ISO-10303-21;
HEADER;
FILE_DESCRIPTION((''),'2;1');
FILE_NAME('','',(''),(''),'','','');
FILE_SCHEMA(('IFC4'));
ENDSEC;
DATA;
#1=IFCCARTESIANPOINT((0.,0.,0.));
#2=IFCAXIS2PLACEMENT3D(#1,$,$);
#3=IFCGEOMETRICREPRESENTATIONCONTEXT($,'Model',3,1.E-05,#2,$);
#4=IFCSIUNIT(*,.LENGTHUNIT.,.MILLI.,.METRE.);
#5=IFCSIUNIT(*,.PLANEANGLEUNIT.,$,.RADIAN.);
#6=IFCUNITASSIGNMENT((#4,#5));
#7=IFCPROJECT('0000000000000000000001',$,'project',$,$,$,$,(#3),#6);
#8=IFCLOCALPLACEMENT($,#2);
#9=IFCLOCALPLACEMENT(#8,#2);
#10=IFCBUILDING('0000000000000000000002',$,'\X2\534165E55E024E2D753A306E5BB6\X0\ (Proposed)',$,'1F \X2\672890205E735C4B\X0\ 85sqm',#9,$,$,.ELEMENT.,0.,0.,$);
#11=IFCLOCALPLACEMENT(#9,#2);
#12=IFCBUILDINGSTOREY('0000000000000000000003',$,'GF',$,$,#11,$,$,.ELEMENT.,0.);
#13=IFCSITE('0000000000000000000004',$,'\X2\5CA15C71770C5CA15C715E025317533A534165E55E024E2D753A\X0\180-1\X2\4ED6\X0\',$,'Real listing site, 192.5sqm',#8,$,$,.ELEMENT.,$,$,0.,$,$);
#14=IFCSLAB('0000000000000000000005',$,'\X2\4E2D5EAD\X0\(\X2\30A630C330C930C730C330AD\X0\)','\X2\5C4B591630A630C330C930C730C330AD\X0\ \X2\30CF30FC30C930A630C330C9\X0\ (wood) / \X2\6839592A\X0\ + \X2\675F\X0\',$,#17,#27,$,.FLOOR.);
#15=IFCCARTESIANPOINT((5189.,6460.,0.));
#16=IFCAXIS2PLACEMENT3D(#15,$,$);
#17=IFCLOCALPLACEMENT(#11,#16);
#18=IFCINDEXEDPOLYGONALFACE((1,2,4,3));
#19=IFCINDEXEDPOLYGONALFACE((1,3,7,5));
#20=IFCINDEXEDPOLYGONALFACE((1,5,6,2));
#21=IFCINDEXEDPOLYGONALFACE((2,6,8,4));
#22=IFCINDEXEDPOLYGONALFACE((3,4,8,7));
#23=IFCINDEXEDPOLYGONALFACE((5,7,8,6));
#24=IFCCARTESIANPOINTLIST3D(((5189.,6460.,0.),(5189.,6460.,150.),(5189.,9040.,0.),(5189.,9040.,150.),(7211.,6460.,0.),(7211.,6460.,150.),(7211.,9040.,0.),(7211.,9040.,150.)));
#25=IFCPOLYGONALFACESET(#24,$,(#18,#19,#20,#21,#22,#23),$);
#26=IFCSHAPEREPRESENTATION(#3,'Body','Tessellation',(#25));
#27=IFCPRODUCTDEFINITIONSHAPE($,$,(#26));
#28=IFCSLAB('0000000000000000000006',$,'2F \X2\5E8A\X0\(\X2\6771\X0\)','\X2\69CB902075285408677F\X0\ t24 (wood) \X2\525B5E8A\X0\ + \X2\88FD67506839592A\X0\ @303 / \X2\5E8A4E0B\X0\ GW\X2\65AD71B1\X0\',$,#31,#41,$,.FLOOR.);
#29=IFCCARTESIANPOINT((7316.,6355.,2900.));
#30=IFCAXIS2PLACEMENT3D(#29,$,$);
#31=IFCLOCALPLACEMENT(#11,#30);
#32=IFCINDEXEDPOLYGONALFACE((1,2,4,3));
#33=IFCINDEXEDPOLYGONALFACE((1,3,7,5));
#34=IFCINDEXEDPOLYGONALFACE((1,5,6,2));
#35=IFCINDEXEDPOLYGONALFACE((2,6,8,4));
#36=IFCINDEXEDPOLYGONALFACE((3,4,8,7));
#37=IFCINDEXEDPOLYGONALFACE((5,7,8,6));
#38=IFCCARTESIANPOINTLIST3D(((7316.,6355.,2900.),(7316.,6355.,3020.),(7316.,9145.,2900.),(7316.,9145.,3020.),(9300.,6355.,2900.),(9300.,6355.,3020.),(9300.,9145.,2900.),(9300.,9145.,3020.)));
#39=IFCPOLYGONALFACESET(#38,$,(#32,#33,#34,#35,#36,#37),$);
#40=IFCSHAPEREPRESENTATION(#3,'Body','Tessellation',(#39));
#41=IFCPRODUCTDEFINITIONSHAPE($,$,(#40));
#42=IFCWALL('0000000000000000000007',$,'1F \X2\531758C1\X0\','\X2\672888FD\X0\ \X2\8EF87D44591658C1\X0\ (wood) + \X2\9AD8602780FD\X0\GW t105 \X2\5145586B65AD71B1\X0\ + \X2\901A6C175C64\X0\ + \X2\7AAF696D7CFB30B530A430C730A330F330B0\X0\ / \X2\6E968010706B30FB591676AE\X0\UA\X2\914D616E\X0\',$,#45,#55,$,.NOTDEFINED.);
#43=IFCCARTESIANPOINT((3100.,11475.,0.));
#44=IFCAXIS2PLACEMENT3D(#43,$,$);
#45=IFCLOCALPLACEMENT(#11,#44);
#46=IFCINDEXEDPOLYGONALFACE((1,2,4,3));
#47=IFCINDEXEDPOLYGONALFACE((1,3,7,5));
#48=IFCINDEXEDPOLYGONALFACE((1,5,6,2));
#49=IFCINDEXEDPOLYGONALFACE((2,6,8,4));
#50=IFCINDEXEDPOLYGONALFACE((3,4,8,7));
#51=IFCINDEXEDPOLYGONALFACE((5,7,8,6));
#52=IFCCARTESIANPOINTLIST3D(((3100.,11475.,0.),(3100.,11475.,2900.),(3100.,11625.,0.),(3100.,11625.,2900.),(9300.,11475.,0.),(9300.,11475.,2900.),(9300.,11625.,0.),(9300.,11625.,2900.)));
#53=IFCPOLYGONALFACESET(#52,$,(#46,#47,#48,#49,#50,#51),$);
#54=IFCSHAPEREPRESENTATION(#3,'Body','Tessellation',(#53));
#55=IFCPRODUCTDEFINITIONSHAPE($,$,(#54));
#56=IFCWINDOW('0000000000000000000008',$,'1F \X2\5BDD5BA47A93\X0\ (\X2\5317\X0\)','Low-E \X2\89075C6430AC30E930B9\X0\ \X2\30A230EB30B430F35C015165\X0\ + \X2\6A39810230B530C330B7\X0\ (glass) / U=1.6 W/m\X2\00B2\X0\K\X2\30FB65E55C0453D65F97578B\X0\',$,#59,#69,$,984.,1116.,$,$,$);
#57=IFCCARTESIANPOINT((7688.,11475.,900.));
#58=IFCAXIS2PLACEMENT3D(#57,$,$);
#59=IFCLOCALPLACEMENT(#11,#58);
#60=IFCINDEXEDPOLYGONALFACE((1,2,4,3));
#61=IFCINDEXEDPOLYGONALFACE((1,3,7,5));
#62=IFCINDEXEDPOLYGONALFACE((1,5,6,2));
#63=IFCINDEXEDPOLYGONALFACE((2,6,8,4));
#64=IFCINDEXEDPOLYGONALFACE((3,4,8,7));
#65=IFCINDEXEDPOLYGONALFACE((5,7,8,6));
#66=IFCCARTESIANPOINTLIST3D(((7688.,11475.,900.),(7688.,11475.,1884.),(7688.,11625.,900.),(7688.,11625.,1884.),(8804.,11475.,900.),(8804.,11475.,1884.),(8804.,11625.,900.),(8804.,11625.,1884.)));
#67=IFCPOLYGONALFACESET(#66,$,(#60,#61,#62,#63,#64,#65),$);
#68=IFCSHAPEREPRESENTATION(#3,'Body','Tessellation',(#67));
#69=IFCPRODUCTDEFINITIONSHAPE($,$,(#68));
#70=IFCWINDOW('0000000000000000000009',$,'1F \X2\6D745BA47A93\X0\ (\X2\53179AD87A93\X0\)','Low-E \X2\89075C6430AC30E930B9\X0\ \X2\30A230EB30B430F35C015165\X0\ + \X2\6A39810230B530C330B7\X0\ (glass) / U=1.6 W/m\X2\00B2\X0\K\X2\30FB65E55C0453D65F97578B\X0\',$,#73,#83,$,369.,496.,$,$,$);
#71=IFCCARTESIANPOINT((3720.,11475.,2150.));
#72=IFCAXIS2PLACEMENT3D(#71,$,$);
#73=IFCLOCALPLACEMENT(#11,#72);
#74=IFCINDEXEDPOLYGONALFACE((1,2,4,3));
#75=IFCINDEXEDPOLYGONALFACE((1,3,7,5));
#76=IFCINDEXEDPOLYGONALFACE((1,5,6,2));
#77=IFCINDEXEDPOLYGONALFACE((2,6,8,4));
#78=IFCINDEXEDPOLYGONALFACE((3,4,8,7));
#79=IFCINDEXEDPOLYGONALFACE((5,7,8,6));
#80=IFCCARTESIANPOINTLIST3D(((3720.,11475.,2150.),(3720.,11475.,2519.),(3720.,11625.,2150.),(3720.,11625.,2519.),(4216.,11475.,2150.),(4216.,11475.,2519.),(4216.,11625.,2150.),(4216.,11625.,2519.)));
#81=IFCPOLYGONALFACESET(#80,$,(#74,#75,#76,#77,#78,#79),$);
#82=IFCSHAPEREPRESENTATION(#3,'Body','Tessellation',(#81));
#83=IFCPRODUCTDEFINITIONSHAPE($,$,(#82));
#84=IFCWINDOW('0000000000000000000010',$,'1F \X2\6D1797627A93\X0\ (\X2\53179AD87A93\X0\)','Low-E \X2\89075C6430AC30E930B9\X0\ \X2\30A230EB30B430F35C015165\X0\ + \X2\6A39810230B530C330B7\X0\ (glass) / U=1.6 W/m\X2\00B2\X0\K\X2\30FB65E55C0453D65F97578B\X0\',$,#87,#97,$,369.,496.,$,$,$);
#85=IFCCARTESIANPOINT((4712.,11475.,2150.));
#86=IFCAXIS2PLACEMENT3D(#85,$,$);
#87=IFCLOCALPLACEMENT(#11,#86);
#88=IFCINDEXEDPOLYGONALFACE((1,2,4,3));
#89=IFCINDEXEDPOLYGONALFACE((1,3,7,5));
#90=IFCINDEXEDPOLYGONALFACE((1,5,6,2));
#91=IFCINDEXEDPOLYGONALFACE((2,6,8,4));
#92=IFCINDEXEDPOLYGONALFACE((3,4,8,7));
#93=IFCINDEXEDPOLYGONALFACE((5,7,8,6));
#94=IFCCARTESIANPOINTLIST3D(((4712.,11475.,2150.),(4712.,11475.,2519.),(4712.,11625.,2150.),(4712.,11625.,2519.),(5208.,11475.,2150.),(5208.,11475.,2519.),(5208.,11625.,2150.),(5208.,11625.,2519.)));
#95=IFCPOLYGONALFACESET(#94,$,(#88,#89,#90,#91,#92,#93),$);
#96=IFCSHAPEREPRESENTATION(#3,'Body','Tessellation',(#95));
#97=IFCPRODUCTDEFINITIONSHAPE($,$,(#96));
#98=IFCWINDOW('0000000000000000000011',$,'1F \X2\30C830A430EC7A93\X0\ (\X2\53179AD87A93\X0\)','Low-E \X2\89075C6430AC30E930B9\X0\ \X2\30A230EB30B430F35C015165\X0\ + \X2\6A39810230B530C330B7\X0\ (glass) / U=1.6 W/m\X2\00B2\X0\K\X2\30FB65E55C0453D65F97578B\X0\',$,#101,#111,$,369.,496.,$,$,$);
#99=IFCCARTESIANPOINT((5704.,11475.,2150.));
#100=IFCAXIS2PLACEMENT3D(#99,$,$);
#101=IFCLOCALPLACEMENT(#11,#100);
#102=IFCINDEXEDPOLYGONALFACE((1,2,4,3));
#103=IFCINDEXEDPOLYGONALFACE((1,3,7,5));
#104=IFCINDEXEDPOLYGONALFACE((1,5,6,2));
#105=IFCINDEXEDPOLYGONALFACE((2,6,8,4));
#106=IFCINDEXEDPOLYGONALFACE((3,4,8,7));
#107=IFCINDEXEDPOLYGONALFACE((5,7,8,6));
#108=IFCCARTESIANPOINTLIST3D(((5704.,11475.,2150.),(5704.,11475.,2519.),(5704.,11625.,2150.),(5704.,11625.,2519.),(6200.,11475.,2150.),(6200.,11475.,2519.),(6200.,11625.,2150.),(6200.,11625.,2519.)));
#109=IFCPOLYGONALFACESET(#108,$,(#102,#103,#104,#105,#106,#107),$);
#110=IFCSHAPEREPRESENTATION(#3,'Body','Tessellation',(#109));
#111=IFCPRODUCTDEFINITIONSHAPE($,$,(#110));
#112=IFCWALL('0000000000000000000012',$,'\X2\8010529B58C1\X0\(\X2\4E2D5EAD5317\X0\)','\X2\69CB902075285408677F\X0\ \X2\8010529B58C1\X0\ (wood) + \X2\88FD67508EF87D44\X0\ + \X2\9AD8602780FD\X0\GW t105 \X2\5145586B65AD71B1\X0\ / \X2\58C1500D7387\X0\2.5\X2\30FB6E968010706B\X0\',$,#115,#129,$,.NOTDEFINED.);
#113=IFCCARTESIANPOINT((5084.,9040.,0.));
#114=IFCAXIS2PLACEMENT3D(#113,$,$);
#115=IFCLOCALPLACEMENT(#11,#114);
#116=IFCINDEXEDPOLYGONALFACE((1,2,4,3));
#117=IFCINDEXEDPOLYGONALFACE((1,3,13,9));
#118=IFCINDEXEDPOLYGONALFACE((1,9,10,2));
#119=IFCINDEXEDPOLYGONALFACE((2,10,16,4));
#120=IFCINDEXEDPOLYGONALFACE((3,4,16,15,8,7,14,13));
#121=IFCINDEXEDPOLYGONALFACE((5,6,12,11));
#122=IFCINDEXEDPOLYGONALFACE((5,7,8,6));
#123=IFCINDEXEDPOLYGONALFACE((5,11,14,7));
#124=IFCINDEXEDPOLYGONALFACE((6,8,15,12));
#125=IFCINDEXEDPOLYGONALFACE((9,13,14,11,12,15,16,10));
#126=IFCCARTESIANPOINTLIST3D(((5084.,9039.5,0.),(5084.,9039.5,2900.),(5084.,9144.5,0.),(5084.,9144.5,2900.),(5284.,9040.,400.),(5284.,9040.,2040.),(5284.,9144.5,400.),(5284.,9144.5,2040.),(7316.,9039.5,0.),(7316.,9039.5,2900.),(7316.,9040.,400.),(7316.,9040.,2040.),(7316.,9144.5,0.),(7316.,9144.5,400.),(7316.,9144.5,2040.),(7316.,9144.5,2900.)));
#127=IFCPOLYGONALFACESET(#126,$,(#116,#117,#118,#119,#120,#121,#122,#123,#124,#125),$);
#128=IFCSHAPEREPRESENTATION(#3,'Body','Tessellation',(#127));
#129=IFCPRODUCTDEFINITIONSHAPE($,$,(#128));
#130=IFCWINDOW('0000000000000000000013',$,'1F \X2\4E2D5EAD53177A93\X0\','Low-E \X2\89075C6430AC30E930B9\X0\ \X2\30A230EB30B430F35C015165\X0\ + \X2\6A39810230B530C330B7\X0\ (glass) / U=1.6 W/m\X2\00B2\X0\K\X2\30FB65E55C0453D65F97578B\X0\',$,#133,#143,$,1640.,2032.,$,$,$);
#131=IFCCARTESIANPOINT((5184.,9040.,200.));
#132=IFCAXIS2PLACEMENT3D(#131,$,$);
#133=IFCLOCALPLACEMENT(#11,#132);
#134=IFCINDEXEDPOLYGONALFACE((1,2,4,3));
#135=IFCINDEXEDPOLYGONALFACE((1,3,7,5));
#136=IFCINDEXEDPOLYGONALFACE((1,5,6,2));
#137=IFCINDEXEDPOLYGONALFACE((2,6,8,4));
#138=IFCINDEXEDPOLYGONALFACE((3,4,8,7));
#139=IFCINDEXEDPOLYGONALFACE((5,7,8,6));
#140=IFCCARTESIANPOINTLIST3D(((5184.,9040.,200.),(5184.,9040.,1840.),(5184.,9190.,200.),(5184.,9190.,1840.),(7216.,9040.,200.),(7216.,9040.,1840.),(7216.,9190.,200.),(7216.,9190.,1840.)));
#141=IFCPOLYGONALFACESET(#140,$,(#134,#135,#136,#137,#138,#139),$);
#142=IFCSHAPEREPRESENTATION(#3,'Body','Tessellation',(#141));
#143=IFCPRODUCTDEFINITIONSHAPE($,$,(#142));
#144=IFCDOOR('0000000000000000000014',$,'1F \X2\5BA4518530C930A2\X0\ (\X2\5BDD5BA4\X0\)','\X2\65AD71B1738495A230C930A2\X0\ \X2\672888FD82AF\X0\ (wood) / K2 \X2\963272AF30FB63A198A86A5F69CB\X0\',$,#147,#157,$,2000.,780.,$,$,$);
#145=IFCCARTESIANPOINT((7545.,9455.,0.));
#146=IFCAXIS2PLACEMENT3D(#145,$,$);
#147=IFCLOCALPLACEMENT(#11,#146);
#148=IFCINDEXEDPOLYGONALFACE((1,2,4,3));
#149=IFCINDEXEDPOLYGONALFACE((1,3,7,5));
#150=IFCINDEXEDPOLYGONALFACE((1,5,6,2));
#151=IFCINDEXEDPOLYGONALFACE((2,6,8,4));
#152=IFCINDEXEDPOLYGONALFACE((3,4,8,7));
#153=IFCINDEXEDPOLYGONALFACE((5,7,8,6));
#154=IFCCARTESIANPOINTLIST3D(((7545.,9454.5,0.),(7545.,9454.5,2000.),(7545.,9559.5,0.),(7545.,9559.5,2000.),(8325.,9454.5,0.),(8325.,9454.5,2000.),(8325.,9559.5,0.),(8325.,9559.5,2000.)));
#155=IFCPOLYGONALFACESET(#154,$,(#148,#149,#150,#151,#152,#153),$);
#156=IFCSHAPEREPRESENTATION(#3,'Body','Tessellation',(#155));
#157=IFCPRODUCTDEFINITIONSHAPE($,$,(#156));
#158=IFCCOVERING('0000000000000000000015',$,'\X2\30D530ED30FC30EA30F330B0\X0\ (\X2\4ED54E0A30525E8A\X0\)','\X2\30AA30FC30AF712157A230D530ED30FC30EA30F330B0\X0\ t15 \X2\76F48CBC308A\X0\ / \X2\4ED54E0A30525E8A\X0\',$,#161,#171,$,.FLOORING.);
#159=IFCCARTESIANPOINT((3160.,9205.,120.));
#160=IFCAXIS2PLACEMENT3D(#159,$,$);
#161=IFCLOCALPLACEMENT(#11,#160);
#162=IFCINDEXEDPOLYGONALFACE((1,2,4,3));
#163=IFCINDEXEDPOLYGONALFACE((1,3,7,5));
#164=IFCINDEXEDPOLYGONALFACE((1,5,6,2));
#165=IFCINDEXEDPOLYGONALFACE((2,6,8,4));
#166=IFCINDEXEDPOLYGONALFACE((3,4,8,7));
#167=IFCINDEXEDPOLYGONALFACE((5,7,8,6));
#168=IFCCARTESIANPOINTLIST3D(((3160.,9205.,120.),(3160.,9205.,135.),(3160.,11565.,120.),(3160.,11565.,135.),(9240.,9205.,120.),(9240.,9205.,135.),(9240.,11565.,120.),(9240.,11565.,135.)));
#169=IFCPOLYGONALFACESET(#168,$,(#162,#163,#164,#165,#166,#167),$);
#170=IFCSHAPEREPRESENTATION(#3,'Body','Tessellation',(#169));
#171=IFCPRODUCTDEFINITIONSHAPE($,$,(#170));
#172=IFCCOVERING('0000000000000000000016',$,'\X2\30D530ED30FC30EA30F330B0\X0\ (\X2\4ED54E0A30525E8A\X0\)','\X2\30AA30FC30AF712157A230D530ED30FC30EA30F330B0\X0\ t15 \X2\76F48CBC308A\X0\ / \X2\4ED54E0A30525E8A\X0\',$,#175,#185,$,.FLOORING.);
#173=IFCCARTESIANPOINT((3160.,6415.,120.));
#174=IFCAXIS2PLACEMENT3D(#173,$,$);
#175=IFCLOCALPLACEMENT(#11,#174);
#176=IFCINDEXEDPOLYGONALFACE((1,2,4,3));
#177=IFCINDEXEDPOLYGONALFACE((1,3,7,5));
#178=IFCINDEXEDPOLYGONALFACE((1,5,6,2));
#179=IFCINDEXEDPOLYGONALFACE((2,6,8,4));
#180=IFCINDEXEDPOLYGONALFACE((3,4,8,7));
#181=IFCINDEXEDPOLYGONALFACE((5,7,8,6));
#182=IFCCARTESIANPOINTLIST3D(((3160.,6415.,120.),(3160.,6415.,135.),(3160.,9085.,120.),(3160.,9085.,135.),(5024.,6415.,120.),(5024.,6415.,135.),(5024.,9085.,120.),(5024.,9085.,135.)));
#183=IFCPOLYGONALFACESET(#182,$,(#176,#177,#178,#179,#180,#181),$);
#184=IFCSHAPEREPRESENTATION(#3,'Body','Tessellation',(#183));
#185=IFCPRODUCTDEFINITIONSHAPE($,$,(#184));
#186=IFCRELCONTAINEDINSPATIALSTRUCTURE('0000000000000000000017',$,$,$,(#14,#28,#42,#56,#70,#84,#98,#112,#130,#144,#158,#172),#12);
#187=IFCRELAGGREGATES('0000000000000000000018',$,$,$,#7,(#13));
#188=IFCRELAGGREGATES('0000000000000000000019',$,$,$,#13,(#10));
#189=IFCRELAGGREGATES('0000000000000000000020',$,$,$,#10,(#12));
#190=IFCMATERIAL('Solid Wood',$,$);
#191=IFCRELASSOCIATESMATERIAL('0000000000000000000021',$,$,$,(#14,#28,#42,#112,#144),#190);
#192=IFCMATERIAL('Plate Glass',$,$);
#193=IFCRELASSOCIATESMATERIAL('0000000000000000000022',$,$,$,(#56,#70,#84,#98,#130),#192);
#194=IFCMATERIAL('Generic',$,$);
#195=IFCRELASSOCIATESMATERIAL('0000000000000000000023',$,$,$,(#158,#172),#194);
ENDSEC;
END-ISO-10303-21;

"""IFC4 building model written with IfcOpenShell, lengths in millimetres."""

from ifc_helpers import new_model, si_unit, frame, frame_2d, origin, place, context, project, spatial, rectangle, extrude, material, element, fill, save


model = new_model("IFC4")

# Units and contexts
model_context = context("Model", 3, precision=1e-05, world=origin())
ifc_project = project(units=[si_unit("LENGTHUNIT", "METRE", prefix="MILLI"), si_unit("PLANEANGLEUNIT", "RADIAN")], contexts=[model_context])

# Site, building, storey
site_placement = place(None, origin())
site = spatial("IfcSite", under=ifc_project, at=site_placement, Name="岡山県岡山市北区十日市中町180-1他", ObjectType="Real listing site, 192.5sqm", CompositionType="ELEMENT", RefElevation=0.0)
building_placement = place(site_placement, origin())
building = spatial("IfcBuilding", under=site, at=building_placement, Name="十日市中町の家 (Proposed)", ObjectType="1F 木造平屋 85sqm", CompositionType="ELEMENT", ElevationOfRefHeight=0.0, ElevationOfTerrain=0.0)
storey_placement = place(building_placement, origin())
storey = spatial("IfcBuildingStorey", under=building, at=storey_placement, Name="GF", CompositionType="ELEMENT", Elevation=0.0)

# Slabs
ifc_material_1 = material(Name="Solid Wood")
slab_1_placement = place(storey_placement, frame((5189.0, 6460.0, 0.0)))
element("IfcSlab", 1, at=slab_1_placement, inside=storey, material=ifc_material_1, Name="中庭(ウッドデッキ)", Description="屋外ウッドデッキ ハードウッド (wood) / 根太 + 束", PredefinedType="FLOOR", context=model_context, shape_type="SweptSolid", body=[
    extrude(rectangle(XDim=2022.0, YDim=2580.0, at=frame_2d((1011.0, 1290.0))), frame((5189.0, 6460.0, 0.0)), (0.0, 0.0, 1.0), 150.0),
])
slab_2_placement = place(storey_placement, frame((7316.0, 6355.0, 2900.0)))
element("IfcSlab", 2, at=slab_2_placement, inside=storey, material=ifc_material_1, Name="2F 床(東)", Description="構造用合板 t24 (wood) 剛床 + 製材根太 @303 / 床下 GW断熱", PredefinedType="FLOOR", context=model_context, shape_type="SweptSolid", body=[
    extrude(rectangle(XDim=1984.0, YDim=2790.0, at=frame_2d((992.0, 1395.0))), frame((7316.0, 6355.0, 2900.0)), (0.0, 0.0, 1.0), 120.0),
])

# Wall, openings, windows
wall_1_placement = place(storey_placement, frame((3100.0, 11475.0, 0.0)))
wall_1 = element("IfcWall", 3, at=wall_1_placement, inside=storey, material=ifc_material_1, Name="1F 北壁", Description="木製 軸組外壁 (wood) + 高性能GW t105 充填断熱 + 通気層 + 窯業系サイディング / 準耐火・外皮UA配慮", PredefinedType="NOTDEFINED", context=model_context, shape_type="SweptSolid", body=[
    extrude(rectangle(XDim=6200.0, YDim=150.0, at=frame_2d((3100.0, 75.0))), frame((3100.0, 11475.0, 0.0)), (0.0, 0.0, 1.0), 2900.0),
])
opening_1_placement = place(storey_placement, frame((7688.0, 11475.0, 900.0)))
opening_1 = element("IfcOpeningElement", 4, at=opening_1_placement, cuts=wall_1, PredefinedType="NOTDEFINED", context=model_context, shape_type="SweptSolid", body=[
    extrude(rectangle(XDim=1116.0, YDim=150.0, at=frame_2d((558.0, 75.0))), frame((7688.0, 11475.0, 900.0)), (0.0, 0.0, 1.0), 984.0),
])
opening_2_placement = place(storey_placement, frame((3720.0, 11475.0, 2150.0)))
opening_2 = element("IfcOpeningElement", 5, at=opening_2_placement, cuts=wall_1, PredefinedType="NOTDEFINED", context=model_context, shape_type="SweptSolid", body=[
    extrude(rectangle(XDim=496.0, YDim=150.0, at=frame_2d((248.0, 75.0))), frame((3720.0, 11475.0, 2150.0)), (0.0, 0.0, 1.0), 369.0),
])
opening_3_placement = place(storey_placement, frame((4712.0, 11475.0, 2150.0)))
opening_3 = element("IfcOpeningElement", 6, at=opening_3_placement, cuts=wall_1, PredefinedType="NOTDEFINED", context=model_context, shape_type="SweptSolid", body=[
    extrude(rectangle(XDim=496.0, YDim=150.0, at=frame_2d((248.0, 75.0))), frame((4712.0, 11475.0, 2150.0)), (0.0, 0.0, 1.0), 369.0),
])
opening_4_placement = place(storey_placement, frame((5704.0, 11475.0, 2150.0)))
opening_4 = element("IfcOpeningElement", 7, at=opening_4_placement, cuts=wall_1, PredefinedType="NOTDEFINED", context=model_context, shape_type="SweptSolid", body=[
    extrude(rectangle(XDim=496.0, YDim=150.0, at=frame_2d((248.0, 75.0))), frame((5704.0, 11475.0, 2150.0)), (0.0, 0.0, 1.0), 369.0),
])
ifc_material_2 = material(Name="Plate Glass")
window_1_placement = place(storey_placement, frame((7688.0, 11475.0, 900.0)))
window_1 = element("IfcWindow", 8, at=window_1_placement, inside=storey, material=ifc_material_2, Name="1F 寝室窓 (北)", Description="Low-E 複層ガラス アルゴン封入 + 樹脂サッシ (glass) / U=1.6 W/m²K・日射取得型", OverallHeight=984.0, OverallWidth=1116.0, context=model_context, shape_type="SweptSolid", body=[
    extrude(rectangle(XDim=1116.0, YDim=150.0, at=frame_2d((558.0, 75.0))), frame((7688.0, 11475.0, 900.0)), (0.0, 0.0, 1.0), 984.0),
])
fill(opening_1, window_1)
window_2_placement = place(storey_placement, frame((3720.0, 11475.0, 2150.0)))
window_2 = element("IfcWindow", 9, at=window_2_placement, inside=storey, material=ifc_material_2, Name="1F 浴室窓 (北高窓)", Description="Low-E 複層ガラス アルゴン封入 + 樹脂サッシ (glass) / U=1.6 W/m²K・日射取得型", OverallHeight=369.0, OverallWidth=496.0, context=model_context, shape_type="SweptSolid", body=[
    extrude(rectangle(XDim=496.0, YDim=150.0, at=frame_2d((248.0, 75.0))), frame((3720.0, 11475.0, 2150.0)), (0.0, 0.0, 1.0), 369.0),
])
fill(opening_2, window_2)
window_3_placement = place(storey_placement, frame((4712.0, 11475.0, 2150.0)))
window_3 = element("IfcWindow", 10, at=window_3_placement, inside=storey, material=ifc_material_2, Name="1F 洗面窓 (北高窓)", Description="Low-E 複層ガラス アルゴン封入 + 樹脂サッシ (glass) / U=1.6 W/m²K・日射取得型", OverallHeight=369.0, OverallWidth=496.0, context=model_context, shape_type="SweptSolid", body=[
    extrude(rectangle(XDim=496.0, YDim=150.0, at=frame_2d((248.0, 75.0))), frame((4712.0, 11475.0, 2150.0)), (0.0, 0.0, 1.0), 369.0),
])
fill(opening_3, window_3)
window_4_placement = place(storey_placement, frame((5704.0, 11475.0, 2150.0)))
window_4 = element("IfcWindow", 11, at=window_4_placement, inside=storey, material=ifc_material_2, Name="1F トイレ窓 (北高窓)", Description="Low-E 複層ガラス アルゴン封入 + 樹脂サッシ (glass) / U=1.6 W/m²K・日射取得型", OverallHeight=369.0, OverallWidth=496.0, context=model_context, shape_type="SweptSolid", body=[
    extrude(rectangle(XDim=496.0, YDim=150.0, at=frame_2d((248.0, 75.0))), frame((5704.0, 11475.0, 2150.0)), (0.0, 0.0, 1.0), 369.0),
])
fill(opening_4, window_4)

# Wall, opening, window
wall_2_placement = place(storey_placement, frame((5084.0, 9040.0, 0.0)))
wall_2 = element("IfcWall", 12, at=wall_2_placement, inside=storey, material=ifc_material_1, Name="耐力壁(中庭北)", Description="構造用合板 耐力壁 (wood) + 製材軸組 + 高性能GW t105 充填断熱 / 壁倍率2.5・準耐火", PredefinedType="NOTDEFINED", context=model_context, shape_type="SweptSolid", body=[
    extrude(rectangle(XDim=2232.0, YDim=105.0, at=frame_2d((1116.0, 52.0))), frame((5084.0, 9040.0, 0.0)), (0.0, 0.0, 1.0), 2900.0),
])
opening_5_placement = place(storey_placement, frame((5184.0, 9040.0, 200.0)))
opening_5 = element("IfcOpeningElement", 13, at=opening_5_placement, cuts=wall_2, PredefinedType="NOTDEFINED", context=model_context, shape_type="SweptSolid", body=[
    extrude(rectangle(XDim=2032.0, YDim=150.0, at=frame_2d((1016.0, 75.0))), frame((5184.0, 9040.0, 200.0)), (0.0, 0.0, 1.0), 1640.0),
])
window_5_placement = place(storey_placement, frame((5184.0, 9040.0, 200.0)))
window_5 = element("IfcWindow", 14, at=window_5_placement, inside=storey, material=ifc_material_2, Name="1F 中庭北窓", Description="Low-E 複層ガラス アルゴン封入 + 樹脂サッシ (glass) / U=1.6 W/m²K・日射取得型", OverallHeight=1640.0, OverallWidth=2032.0, context=model_context, shape_type="SweptSolid", body=[
    extrude(rectangle(XDim=2032.0, YDim=150.0, at=frame_2d((1016.0, 75.0))), frame((5184.0, 9040.0, 200.0)), (0.0, 0.0, 1.0), 1640.0),
])
fill(opening_5, window_5)

# Door
door_1_placement = place(storey_placement, frame((7545.0, 9455.0, 0.0)))
element("IfcDoor", 15, at=door_1_placement, inside=storey, material=ifc_material_1, Name="1F 室内ドア (寝室)", Description="断熱玄関ドア 木製芯 (wood) / K2 防犯・採風機構", OverallHeight=2000.0, OverallWidth=780.0, context=model_context, shape_type="SweptSolid", body=[
    extrude(rectangle(XDim=780.0, YDim=105.0, at=frame_2d((390.0, 52.0))), frame((7545.0, 9455.0, 0.0)), (0.0, 0.0, 1.0), 2000.0),
])

# Coverings
ifc_material_3 = material(Name="Generic")
covering_1_placement = place(storey_placement, frame((3160.0, 9205.0, 120.0)))
element("IfcCovering", 16, at=covering_1_placement, inside=storey, material=ifc_material_3, Name="フローリング (仕上げ床)", Description="オーク無垢フローリング t15 直貼り / 仕上げ床", PredefinedType="FLOORING", context=model_context, shape_type="SweptSolid", body=[
    extrude(rectangle(XDim=6080.0, YDim=2360.0, at=frame_2d((3040.0, 1180.0))), frame((3160.0, 9205.0, 120.0)), (0.0, 0.0, 1.0), 15.0),
])
covering_2_placement = place(storey_placement, frame((3160.0, 6415.0, 120.0)))
element("IfcCovering", 17, at=covering_2_placement, inside=storey, material=ifc_material_3, Name="フローリング (仕上げ床)", Description="オーク無垢フローリング t15 直貼り / 仕上げ床", PredefinedType="FLOORING", context=model_context, shape_type="SweptSolid", body=[
    extrude(rectangle(XDim=1864.0, YDim=2670.0, at=frame_2d((932.0, 1335.0))), frame((3160.0, 6415.0, 120.0)), (0.0, 0.0, 1.0), 15.0),
])

save(model, "model.ifc")
